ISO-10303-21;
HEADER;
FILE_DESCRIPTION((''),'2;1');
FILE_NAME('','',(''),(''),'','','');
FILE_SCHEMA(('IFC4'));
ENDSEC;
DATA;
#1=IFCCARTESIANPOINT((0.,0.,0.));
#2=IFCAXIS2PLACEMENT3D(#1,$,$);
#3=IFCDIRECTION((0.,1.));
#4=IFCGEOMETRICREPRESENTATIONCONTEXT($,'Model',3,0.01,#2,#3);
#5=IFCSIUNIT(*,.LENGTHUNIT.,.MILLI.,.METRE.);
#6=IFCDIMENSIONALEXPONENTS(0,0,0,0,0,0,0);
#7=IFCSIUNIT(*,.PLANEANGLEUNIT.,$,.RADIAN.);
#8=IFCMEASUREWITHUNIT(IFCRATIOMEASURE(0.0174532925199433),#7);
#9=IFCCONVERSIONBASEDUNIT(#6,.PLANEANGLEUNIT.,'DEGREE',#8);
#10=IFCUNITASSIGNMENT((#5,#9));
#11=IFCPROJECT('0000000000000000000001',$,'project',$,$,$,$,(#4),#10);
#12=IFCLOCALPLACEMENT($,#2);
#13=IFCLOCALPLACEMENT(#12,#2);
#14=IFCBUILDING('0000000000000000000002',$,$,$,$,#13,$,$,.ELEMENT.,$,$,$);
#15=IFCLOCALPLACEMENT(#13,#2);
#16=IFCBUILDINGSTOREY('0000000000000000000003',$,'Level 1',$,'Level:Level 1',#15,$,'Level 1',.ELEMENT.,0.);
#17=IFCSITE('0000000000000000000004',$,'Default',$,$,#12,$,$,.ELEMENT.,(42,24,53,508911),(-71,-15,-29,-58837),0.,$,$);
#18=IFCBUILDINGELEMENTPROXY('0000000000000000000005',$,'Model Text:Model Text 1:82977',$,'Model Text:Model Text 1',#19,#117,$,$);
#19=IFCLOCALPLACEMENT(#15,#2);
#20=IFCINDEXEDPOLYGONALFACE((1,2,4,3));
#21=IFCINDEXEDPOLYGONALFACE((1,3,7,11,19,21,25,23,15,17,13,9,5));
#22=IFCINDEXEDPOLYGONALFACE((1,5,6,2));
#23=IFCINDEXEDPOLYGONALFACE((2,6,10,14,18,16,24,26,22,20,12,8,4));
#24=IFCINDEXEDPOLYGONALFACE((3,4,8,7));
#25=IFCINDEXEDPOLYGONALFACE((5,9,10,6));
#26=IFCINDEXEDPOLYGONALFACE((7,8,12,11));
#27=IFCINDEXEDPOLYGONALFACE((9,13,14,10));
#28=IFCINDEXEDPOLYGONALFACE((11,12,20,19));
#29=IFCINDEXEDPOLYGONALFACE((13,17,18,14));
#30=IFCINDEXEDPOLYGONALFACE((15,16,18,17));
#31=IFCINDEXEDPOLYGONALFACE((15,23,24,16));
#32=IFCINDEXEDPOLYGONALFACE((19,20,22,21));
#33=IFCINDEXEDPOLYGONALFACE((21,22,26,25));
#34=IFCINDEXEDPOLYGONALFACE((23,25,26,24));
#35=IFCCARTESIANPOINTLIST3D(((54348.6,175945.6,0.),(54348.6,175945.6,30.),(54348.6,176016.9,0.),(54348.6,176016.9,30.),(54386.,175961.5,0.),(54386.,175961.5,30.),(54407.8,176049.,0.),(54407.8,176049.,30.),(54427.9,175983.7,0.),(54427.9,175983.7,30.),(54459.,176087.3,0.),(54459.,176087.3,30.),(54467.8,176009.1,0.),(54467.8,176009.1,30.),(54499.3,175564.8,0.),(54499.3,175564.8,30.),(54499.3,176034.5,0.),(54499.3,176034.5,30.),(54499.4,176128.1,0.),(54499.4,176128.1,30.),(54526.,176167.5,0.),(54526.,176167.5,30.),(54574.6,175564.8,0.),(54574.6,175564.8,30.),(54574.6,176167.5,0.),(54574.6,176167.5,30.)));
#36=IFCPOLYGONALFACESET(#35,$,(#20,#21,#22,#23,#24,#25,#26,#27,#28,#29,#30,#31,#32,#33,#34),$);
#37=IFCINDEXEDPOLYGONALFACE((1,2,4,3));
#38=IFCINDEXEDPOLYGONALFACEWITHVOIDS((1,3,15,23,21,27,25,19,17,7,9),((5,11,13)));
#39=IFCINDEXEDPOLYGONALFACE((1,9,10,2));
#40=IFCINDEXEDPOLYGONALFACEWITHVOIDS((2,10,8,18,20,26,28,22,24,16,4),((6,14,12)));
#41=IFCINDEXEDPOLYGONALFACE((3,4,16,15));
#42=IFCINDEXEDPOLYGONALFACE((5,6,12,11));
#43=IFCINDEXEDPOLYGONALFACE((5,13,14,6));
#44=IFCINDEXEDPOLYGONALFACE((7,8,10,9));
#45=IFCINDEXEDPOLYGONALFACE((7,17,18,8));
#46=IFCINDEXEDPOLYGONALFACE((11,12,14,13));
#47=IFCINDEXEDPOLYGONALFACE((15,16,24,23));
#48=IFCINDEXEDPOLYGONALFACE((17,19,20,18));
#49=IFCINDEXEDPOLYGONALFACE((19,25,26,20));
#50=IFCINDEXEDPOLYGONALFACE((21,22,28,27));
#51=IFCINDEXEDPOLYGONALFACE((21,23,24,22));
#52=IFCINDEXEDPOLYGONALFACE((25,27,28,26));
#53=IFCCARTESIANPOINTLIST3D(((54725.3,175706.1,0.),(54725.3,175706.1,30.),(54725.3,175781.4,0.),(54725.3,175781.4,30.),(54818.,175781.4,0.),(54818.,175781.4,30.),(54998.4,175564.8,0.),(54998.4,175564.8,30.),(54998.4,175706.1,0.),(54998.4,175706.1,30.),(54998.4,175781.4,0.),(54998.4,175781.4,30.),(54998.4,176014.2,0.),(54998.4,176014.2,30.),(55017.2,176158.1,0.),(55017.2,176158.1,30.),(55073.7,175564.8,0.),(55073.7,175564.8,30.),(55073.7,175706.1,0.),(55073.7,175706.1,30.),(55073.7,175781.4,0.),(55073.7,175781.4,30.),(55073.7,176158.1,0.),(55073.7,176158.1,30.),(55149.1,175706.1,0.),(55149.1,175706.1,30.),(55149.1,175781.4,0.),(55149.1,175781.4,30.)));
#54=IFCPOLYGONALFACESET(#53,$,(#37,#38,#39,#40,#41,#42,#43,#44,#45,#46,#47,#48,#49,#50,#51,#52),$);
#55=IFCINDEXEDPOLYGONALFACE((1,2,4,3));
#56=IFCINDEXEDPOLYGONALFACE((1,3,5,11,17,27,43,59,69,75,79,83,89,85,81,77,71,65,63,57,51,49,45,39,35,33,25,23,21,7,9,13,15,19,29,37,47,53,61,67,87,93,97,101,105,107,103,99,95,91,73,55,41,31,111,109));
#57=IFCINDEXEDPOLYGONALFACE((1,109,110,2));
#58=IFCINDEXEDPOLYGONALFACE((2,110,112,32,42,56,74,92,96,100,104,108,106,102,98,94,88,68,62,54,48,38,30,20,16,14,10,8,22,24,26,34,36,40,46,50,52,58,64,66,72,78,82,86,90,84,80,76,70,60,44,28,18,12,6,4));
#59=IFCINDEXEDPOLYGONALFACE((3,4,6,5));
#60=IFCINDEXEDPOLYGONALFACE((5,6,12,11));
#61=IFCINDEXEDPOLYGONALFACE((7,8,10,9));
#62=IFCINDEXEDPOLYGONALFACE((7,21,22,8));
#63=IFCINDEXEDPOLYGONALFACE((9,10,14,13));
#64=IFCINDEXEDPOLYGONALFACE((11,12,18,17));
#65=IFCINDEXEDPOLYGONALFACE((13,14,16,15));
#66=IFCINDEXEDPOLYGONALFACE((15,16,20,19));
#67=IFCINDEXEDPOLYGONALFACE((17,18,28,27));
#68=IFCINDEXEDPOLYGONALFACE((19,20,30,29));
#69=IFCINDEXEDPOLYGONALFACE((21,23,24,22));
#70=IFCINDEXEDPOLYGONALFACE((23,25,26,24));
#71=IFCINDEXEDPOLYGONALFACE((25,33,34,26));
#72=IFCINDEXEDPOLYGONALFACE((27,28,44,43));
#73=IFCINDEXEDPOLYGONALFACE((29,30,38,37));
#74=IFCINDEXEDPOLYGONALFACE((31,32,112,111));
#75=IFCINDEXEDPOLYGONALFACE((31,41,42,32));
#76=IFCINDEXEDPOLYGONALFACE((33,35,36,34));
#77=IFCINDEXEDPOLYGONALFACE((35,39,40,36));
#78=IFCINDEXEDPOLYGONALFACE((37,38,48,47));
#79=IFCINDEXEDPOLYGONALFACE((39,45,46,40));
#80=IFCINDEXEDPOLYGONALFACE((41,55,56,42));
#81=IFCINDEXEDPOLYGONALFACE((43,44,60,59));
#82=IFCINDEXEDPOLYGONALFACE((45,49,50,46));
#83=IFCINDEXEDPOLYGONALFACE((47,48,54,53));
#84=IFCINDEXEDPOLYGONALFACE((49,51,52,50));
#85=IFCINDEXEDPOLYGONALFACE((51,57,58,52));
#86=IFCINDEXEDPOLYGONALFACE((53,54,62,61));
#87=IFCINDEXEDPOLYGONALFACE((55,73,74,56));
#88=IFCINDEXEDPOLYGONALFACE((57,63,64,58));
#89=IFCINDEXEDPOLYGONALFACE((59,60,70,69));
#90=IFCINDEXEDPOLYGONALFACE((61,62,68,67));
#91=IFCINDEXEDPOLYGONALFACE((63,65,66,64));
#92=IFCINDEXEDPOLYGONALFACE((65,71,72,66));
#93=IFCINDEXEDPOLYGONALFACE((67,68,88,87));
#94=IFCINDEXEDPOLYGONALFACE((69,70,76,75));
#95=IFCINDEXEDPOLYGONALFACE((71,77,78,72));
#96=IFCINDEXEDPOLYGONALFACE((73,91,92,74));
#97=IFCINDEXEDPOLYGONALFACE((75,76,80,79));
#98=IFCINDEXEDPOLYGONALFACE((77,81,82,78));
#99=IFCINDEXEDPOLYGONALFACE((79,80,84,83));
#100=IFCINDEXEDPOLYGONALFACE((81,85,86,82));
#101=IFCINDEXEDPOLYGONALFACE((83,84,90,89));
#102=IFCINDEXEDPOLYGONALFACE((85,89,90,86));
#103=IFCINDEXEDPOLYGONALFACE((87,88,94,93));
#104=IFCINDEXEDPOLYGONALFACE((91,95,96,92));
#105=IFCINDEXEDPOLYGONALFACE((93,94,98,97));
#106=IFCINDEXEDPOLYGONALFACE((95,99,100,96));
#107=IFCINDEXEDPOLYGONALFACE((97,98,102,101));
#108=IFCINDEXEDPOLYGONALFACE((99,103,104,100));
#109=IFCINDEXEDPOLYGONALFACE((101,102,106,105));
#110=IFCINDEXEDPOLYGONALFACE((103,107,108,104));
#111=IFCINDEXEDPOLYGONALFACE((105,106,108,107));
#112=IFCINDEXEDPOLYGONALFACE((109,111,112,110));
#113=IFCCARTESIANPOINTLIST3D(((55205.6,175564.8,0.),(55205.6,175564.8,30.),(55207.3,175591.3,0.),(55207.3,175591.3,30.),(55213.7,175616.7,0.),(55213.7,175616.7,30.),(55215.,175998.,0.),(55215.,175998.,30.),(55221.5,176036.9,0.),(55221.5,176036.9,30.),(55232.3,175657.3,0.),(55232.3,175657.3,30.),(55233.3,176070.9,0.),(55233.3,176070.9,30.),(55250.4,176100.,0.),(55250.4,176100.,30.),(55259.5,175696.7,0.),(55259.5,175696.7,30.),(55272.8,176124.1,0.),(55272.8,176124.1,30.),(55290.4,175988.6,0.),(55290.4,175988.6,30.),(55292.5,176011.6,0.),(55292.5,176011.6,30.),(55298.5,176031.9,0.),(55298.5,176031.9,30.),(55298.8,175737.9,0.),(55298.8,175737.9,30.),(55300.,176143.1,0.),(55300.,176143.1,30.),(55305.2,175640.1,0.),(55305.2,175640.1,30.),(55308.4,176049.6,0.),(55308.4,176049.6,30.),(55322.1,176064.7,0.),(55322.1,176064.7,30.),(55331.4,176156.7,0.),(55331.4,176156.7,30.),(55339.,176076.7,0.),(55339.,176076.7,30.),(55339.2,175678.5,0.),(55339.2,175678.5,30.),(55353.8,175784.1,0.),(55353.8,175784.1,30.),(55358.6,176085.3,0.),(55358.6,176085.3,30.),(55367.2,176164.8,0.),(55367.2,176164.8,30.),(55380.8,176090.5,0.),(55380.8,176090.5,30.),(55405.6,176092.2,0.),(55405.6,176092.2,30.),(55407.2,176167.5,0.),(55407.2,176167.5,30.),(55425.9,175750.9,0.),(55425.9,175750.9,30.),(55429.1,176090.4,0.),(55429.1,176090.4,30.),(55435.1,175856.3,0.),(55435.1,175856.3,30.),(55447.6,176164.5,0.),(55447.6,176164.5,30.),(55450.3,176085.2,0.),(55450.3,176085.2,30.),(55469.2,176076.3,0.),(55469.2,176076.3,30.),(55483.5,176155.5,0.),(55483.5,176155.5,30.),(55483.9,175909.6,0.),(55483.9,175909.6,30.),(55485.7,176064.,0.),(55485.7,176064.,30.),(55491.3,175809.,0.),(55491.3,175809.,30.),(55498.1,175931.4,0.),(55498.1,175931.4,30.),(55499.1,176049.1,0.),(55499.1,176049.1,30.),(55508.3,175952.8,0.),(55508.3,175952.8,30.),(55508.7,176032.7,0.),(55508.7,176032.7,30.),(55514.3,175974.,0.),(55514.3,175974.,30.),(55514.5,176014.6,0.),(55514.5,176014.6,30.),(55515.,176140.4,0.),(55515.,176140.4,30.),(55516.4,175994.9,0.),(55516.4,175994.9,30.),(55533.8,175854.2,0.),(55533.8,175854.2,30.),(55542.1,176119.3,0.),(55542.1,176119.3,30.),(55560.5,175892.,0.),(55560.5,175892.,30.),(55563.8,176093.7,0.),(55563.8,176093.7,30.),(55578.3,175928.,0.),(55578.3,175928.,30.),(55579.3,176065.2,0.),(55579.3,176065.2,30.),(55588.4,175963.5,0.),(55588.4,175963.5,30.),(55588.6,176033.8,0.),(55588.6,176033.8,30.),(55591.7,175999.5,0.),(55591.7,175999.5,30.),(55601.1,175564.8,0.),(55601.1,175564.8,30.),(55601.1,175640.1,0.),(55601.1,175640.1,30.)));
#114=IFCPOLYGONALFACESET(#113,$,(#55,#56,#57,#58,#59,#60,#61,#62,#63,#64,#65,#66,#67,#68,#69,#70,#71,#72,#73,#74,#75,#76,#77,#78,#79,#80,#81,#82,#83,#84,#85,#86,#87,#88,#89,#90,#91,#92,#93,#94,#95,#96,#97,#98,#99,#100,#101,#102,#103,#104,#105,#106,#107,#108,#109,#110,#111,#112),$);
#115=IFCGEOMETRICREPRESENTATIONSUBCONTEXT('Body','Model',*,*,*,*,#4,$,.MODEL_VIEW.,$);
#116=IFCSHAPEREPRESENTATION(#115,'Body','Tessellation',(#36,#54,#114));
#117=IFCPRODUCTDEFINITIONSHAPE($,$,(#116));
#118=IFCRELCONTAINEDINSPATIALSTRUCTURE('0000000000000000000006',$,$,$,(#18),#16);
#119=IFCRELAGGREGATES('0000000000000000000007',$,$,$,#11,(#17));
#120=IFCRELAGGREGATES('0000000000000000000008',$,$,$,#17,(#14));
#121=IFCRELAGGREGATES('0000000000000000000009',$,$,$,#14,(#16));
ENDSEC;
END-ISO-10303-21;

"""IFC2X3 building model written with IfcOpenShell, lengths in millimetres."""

from ifc_helpers import new_model, entity, si_unit, converted_unit, direction, frame, origin, place, context, subcontext, project, spatial, polyline, outline, extrude, element, save


model = new_model("IFC2X3")

# Units and contexts
model_context = context("Model", 3, precision=0.01, world=origin(), true_north=direction((0.0, 1.0)))
body_context = subcontext(model_context, "Body", "Model", "MODEL_VIEW")
ifc_project = project(units=[si_unit("LENGTHUNIT", "METRE", prefix="MILLI"), converted_unit("PLANEANGLEUNIT", "DEGREE", entity("IfcRatioMeasure", 0.0174532925199433), si_unit("PLANEANGLEUNIT", "RADIAN"), dimensions=[0, 0, 0, 0, 0, 0, 0])], contexts=[model_context])

# Site, building, storey
site_placement = place(None, origin())
site = spatial("IfcSite", under=ifc_project, at=site_placement, Name="Default", CompositionType="ELEMENT", RefLatitude=(42, 24, 53, 508911), RefLongitude=(-71, -15, -29, -58837), RefElevation=0.0)
building_placement = place(site_placement, origin())
building = spatial("IfcBuilding", under=site, at=building_placement, CompositionType="ELEMENT")
storey_placement = place(building_placement, origin())
storey = spatial("IfcBuildingStorey", under=building, at=storey_placement, Name="Level 1", ObjectType="Level:Level 1", LongName="Level 1", CompositionType="ELEMENT", Elevation=0.0)

# Building element proxy
proxy_1_placement = place(storey_placement, origin())
element("IfcBuildingElementProxy", 1, at=proxy_1_placement, inside=storey, Name="Model Text:Model Text 1:82977", ObjectType="Model Text:Model Text 1", context=body_context, shape_type="SweptSolid", body=[
    extrude(outline(polyline([(-410.6, -111.6), (192.1, -111.6), (192.1, -63.1), (152.7, -36.4), (111.9, 4.0), (73.6, 55.2), (41.4, 114.4), (-29.8, 114.4), (-13.9, 77.0), (8.3, 35.1), (33.7, -4.8), (59.1, -36.3), (-410.6, -36.3), (-410.6, -111.6)])), frame((54463.0, 175975.4, 0.0), z_axis=(0.0, 0.0, 1.0), x_axis=(0.0, 1.0, 0.0)), (0.0, 0.0, 1.0), 30.0),
    extrude(outline(polyline([(-6.8, -218.3), (68.5, -218.3), (68.5, -77.1), (143.8, -77.1), (143.8, -1.7), (68.5, -1.7), (68.5, 375.0), (12.0, 375.0), (-280.0, -1.7), (-280.0, -77.1), (-6.8, -77.1), (-6.8, -218.3)]), holes=[polyline([(-6.8, -1.7), (-187.3, -1.7), (-6.8, 231.1), (-6.8, -1.7)])]), frame((55005.3, 175783.1, 0.0)), (0.0, 0.0, 1.0), 30.0),
    extrude(outline(polyline([(-190.2, -317.5), (-190.2, -392.8), (205.4, -392.8), (203.7, -366.3), (197.3, -340.9), (178.7, -300.3), (151.5, -260.9), (112.2, -219.7), (57.2, -173.6), (-24.1, -101.3), (-72.9, -48.0), (-87.1, -26.3), (-97.3, -4.8), (-103.4, 16.4), (-105.4, 37.3), (-103.5, 57.0), (-97.7, 75.0), (-88.2, 91.5), (-74.7, 106.4), (-58.2, 118.7), (-39.4, 127.5), (-18.2, 132.8), (5.4, 134.6), (30.2, 132.9), (52.4, 127.7), (72.0, 119.1), (88.9, 107.1), (102.6, 92.0), (112.5, 74.3), (118.5, 54.0), (120.6, 31.0), (196.0, 40.4), (189.5, 79.3), (177.7, 113.3), (160.6, 142.4), (138.2, 166.5), (111.0, 185.5), (79.5, 199.1), (43.8, 207.2), (3.8, 209.9), (-36.6, 206.9), (-72.5, 197.9), (-104.0, 182.8), (-131.1, 161.7), (-152.8, 136.1), (-168.3, 107.6), (-177.6, 76.2), (-180.8, 41.9), (-177.4, 5.8), (-167.4, -29.6), (-149.5, -65.6), (-122.8, -103.4), (-80.3, -148.6), (-14.9, -206.7), (71.8, -279.1), (105.8, -317.5), (-190.2, -317.5)])), frame((55411.0, 175957.6, 0.0), z_axis=(0.0, 0.0, -1.0), x_axis=(-1.0, 0.0, 0.0)), (0.0, 0.0, -1.0), 30.0),
])

save(model, "model.ifc")
